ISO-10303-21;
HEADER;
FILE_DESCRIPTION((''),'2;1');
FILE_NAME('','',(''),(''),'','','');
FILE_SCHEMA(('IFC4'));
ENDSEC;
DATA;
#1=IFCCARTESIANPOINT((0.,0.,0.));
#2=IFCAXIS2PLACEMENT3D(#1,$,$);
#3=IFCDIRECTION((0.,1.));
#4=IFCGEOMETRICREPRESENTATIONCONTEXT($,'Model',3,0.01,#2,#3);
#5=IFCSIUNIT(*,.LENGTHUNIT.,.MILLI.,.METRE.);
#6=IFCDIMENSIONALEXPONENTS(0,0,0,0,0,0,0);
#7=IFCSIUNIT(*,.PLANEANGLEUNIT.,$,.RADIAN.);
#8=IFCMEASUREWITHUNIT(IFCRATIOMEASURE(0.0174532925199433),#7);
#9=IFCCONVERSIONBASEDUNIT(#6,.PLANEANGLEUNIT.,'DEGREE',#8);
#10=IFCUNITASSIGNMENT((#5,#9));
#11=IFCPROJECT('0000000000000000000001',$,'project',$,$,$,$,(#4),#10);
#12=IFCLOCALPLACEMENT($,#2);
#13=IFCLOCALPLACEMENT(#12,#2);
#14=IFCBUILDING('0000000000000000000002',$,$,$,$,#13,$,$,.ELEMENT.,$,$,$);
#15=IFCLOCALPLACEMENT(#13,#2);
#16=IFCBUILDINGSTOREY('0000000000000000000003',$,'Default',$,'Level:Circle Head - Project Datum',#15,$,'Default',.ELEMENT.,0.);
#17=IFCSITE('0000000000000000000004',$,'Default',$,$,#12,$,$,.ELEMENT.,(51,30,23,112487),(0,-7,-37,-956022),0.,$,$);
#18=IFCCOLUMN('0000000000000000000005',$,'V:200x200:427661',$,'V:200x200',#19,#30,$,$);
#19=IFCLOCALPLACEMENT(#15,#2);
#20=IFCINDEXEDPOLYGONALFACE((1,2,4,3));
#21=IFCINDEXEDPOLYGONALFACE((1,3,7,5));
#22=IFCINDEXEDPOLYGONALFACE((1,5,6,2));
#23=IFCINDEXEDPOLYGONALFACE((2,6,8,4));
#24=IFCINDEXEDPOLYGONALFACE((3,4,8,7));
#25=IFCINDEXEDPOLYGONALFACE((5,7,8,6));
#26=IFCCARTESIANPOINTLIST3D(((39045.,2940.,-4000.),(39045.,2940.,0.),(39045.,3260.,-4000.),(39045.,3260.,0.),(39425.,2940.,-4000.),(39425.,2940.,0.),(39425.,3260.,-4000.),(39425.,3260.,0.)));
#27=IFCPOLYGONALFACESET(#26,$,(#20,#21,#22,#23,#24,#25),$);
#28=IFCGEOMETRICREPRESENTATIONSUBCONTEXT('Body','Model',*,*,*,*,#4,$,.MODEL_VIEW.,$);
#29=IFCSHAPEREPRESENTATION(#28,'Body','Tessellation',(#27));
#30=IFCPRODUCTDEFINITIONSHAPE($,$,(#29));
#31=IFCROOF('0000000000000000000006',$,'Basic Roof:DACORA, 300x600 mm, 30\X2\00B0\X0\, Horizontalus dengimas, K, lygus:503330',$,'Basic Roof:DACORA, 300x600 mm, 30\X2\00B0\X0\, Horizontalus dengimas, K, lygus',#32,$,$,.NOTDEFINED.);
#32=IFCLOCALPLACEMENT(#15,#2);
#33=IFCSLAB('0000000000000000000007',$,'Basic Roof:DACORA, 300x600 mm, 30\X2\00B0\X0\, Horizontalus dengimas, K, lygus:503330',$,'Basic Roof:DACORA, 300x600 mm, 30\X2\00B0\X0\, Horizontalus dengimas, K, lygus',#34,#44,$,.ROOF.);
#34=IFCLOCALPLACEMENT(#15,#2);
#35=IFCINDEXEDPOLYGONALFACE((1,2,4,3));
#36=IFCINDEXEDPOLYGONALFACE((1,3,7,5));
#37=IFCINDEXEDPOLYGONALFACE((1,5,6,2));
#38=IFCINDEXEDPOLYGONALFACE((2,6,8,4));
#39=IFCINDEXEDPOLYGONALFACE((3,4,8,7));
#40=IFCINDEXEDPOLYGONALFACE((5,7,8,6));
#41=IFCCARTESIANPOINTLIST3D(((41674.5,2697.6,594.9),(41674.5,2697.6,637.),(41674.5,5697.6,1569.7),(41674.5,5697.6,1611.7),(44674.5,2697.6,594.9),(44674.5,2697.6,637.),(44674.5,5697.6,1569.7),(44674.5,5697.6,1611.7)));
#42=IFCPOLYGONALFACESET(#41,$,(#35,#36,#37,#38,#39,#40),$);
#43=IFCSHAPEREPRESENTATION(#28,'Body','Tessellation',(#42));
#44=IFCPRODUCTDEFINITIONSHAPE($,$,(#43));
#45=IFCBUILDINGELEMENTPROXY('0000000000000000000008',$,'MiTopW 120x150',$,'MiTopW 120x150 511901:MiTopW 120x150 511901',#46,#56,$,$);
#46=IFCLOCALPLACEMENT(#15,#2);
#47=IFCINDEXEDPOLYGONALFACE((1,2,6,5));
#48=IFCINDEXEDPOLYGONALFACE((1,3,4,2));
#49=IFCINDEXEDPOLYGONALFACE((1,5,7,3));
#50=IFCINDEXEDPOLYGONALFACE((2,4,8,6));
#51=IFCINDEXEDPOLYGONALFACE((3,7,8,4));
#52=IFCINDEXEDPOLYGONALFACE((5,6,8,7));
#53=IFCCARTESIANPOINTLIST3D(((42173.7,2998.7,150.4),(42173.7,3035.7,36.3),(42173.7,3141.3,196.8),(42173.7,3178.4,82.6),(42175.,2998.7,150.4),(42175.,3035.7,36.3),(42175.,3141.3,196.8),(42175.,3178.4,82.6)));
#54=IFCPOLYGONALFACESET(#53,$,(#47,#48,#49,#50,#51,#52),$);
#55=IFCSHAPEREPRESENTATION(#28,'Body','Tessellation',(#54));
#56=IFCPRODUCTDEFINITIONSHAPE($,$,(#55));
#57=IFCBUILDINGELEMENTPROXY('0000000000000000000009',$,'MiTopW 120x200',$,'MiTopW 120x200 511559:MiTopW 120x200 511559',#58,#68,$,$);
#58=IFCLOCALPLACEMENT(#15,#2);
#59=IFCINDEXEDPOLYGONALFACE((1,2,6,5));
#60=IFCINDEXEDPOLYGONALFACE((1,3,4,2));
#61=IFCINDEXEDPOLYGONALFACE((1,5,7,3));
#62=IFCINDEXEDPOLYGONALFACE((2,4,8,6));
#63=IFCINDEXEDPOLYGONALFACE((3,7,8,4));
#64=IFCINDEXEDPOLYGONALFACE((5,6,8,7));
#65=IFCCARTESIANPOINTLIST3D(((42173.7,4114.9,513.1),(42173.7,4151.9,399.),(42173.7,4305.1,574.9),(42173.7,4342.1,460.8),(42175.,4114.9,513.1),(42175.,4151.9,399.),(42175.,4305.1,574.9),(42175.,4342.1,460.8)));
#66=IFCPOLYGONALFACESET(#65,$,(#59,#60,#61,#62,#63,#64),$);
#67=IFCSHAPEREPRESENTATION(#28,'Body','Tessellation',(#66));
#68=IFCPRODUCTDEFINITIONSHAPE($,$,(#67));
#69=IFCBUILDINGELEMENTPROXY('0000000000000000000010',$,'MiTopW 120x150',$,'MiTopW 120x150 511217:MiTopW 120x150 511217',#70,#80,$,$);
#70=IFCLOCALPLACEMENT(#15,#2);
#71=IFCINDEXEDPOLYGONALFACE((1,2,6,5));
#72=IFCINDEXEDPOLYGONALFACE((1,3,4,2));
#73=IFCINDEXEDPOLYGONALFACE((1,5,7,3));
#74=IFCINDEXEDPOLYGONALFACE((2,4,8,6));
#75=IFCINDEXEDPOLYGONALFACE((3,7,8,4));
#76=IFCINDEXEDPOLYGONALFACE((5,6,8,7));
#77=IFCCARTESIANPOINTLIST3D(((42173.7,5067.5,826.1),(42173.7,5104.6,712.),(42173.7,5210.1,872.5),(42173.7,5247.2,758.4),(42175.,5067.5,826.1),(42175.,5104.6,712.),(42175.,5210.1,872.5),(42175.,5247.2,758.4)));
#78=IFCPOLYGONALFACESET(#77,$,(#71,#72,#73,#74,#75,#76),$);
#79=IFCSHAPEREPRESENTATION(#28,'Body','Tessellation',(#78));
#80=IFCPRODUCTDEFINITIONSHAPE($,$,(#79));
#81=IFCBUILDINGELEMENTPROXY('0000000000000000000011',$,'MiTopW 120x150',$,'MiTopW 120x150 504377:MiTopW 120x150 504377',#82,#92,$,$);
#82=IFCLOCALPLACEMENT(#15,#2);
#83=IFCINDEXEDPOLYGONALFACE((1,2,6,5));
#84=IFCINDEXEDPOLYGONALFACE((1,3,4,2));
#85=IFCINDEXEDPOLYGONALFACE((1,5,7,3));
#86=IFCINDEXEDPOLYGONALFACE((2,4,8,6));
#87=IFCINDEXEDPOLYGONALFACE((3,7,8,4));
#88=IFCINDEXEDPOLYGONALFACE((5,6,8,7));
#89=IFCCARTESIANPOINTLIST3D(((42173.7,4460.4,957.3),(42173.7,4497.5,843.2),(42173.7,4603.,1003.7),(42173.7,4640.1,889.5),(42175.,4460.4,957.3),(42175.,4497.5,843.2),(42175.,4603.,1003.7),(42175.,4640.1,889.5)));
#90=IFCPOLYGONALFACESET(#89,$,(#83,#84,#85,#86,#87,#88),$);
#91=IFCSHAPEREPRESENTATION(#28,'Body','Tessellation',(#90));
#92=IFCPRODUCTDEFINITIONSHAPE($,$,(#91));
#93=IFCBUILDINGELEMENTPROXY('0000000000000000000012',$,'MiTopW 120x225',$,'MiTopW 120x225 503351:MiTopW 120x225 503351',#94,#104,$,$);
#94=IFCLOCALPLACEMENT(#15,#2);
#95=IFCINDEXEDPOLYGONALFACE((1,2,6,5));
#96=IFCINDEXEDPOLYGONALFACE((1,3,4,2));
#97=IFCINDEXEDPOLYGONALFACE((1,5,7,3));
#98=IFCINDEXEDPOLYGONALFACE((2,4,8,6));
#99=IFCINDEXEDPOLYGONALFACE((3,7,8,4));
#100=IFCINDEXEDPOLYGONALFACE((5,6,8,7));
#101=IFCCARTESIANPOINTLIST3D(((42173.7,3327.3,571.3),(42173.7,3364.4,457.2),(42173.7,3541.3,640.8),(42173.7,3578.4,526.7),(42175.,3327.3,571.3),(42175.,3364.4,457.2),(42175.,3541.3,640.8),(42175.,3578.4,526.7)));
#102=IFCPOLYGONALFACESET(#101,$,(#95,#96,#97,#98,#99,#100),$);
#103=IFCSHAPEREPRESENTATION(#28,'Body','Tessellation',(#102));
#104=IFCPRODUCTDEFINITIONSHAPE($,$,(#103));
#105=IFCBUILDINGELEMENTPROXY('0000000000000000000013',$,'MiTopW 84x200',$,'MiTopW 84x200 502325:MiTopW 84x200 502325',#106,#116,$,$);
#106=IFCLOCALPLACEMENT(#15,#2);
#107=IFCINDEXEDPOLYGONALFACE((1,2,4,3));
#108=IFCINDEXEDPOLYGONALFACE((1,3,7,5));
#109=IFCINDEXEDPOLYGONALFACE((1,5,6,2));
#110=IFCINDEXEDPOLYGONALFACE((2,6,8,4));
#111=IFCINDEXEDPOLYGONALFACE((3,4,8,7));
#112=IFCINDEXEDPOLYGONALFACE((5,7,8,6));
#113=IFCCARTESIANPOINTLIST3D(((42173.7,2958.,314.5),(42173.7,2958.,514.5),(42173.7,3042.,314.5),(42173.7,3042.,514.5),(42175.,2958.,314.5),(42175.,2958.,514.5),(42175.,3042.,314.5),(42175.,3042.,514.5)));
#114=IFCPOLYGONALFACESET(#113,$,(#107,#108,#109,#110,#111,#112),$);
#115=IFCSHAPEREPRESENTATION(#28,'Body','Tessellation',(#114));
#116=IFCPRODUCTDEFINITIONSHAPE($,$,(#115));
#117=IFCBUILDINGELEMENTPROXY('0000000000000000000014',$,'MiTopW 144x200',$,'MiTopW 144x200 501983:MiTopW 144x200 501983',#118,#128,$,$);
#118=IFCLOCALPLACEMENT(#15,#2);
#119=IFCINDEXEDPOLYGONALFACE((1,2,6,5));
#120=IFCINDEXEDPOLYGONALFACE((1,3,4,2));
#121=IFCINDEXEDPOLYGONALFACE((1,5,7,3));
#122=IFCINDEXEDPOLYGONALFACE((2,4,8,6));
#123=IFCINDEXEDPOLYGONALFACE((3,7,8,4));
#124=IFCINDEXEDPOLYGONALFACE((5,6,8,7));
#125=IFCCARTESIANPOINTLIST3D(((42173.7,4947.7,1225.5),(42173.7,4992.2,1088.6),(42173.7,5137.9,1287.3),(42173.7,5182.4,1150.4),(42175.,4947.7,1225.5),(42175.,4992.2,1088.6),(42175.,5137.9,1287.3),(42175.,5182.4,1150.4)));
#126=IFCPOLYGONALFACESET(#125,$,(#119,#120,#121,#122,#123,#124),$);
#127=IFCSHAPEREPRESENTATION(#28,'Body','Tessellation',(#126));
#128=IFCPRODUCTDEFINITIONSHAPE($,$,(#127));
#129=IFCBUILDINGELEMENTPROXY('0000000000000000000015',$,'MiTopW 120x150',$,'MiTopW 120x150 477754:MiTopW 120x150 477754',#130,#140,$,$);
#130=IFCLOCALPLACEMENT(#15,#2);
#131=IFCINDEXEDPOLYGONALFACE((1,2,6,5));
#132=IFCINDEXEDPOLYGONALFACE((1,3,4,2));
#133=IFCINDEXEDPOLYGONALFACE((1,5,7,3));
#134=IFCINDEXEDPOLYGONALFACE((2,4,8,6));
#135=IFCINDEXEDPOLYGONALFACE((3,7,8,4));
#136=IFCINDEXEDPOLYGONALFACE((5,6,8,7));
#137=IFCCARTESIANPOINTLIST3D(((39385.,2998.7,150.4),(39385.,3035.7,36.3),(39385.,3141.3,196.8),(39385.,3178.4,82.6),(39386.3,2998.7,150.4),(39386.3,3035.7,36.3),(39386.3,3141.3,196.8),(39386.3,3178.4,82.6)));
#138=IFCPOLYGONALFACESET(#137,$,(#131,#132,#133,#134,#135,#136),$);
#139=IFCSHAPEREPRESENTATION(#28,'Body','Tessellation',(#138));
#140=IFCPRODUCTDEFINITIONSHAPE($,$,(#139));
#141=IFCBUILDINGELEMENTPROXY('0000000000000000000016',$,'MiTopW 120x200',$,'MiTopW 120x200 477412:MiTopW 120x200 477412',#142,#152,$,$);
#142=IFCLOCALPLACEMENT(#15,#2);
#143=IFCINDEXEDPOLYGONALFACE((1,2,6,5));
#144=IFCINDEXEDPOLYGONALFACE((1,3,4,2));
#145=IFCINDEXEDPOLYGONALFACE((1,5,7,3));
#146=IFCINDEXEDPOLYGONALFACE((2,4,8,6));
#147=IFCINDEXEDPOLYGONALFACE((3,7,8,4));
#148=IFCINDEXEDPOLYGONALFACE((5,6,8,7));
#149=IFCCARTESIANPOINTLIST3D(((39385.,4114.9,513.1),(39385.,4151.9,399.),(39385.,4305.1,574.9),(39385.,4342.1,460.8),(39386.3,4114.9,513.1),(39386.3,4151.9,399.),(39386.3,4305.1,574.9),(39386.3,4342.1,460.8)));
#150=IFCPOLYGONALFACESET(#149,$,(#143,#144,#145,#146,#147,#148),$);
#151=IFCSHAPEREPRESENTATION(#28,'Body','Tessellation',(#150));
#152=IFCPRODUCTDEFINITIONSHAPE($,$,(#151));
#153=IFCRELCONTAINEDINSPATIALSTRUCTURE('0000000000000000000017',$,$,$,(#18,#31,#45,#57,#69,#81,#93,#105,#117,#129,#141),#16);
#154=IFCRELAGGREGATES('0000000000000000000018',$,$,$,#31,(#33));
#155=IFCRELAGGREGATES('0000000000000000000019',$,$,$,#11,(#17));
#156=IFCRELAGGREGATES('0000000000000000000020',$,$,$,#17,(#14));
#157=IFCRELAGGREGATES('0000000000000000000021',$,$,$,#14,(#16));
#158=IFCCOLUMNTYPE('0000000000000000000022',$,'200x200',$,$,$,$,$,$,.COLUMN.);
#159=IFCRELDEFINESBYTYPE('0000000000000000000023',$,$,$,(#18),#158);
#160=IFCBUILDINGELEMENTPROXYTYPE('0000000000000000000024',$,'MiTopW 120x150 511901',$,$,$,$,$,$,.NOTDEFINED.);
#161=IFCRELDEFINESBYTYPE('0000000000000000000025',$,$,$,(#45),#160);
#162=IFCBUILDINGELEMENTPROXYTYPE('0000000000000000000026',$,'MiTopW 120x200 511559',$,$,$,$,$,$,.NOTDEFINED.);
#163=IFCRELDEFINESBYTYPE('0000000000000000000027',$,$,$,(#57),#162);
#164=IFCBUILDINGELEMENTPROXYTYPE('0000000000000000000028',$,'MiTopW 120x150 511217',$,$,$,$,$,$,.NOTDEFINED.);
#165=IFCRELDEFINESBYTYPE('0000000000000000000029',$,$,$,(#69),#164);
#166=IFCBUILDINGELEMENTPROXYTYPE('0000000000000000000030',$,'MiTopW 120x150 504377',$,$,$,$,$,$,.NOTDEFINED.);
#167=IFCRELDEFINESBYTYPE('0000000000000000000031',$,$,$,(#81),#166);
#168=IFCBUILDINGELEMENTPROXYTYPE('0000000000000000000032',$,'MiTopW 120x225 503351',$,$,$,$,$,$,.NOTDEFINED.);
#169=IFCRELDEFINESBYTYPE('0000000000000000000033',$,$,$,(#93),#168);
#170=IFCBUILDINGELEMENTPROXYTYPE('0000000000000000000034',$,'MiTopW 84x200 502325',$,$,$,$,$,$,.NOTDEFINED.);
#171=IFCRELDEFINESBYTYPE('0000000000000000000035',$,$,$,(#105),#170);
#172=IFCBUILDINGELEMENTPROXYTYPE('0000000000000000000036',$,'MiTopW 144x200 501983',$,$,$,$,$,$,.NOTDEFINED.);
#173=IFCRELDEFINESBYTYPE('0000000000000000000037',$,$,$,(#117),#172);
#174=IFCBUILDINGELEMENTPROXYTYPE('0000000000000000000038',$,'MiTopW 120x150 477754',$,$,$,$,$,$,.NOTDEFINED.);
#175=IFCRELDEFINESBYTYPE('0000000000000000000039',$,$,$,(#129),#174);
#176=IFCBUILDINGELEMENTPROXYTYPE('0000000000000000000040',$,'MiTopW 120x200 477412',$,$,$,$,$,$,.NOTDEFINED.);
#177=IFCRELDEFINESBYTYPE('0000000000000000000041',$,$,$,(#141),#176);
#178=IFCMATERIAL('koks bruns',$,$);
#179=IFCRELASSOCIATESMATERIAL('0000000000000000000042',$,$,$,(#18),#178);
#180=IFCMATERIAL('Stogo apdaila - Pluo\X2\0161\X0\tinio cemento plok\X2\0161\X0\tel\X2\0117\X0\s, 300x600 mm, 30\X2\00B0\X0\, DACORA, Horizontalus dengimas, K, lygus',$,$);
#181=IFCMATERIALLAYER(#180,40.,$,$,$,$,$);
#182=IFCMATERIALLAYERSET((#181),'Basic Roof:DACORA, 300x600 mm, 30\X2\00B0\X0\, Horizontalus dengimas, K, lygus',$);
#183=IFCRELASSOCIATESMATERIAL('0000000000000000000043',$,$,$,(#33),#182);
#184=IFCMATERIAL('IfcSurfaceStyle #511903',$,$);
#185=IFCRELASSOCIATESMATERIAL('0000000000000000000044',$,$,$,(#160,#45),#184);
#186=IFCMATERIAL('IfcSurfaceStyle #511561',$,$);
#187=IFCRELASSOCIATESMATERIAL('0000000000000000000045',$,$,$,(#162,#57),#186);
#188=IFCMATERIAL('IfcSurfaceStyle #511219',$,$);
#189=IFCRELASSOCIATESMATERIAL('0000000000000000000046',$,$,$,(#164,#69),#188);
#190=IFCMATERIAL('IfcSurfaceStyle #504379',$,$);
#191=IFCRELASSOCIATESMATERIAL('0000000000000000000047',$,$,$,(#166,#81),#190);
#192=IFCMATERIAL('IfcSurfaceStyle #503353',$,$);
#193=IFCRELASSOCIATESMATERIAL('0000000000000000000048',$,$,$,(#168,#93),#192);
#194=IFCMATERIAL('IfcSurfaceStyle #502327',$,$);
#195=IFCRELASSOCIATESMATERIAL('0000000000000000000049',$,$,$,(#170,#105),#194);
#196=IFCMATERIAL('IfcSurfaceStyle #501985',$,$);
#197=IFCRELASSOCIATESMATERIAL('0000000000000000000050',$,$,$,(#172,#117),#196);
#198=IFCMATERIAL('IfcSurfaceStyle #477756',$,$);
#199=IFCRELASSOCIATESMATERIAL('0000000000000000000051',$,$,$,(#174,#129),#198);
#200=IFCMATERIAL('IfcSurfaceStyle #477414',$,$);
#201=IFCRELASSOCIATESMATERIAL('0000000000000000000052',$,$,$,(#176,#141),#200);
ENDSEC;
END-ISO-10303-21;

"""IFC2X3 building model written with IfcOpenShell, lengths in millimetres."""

from ifc_helpers import new_model, entity, si_unit, converted_unit, direction, frame, frame_2d, origin, origin_2d_with_axis, place, context, subcontext, project, spatial, polyline, rectangle, outline, extrude, source, transform, mapped, material, layer, layer_set, type_object, type_shapes, element, aggregate, save


model = new_model("IFC2X3")

# Units and contexts
model_context = context("Model", 3, precision=0.01, world=origin(), true_north=direction((0.0, 1.0)))
body_context = subcontext(model_context, "Body", "Model", "MODEL_VIEW")
ifc_project = project(units=[si_unit("LENGTHUNIT", "METRE", prefix="MILLI"), converted_unit("PLANEANGLEUNIT", "DEGREE", entity("IfcRatioMeasure", 0.0174532925199433), si_unit("PLANEANGLEUNIT", "RADIAN"), dimensions=[0, 0, 0, 0, 0, 0, 0])], contexts=[model_context])

# Site, building, storey
site_placement = place(None, origin())
site = spatial("IfcSite", under=ifc_project, at=site_placement, Name="Default", CompositionType="ELEMENT", RefLatitude=(51, 30, 23, 112487), RefLongitude=(0, -7, -37, -956022), RefElevation=0.0)
building_placement = place(site_placement, origin())
building = spatial("IfcBuilding", under=site, at=building_placement, CompositionType="ELEMENT")
storey_placement = place(building_placement, origin())
storey = spatial("IfcBuildingStorey", under=building, at=storey_placement, Name="Default", ObjectType="Level:Circle Head - Project Datum", LongName="Default", CompositionType="ELEMENT", Elevation=0.0)

# Column
ifc_material_1 = material(Name="koks bruns")
column_type_1 = type_object("IfcColumnType", Name="200x200", PredefinedType="COLUMN")
shared_shape_1 = source(origin(), body_context, "Body", "SweptSolid", [
    extrude(rectangle(XDim=380.0, YDim=320.0, at=origin_2d_with_axis()), frame((160.0, 300.0, -4000.0), z_axis=(0.0, 0.0, 1.0), x_axis=(0.0, -1.0, 0.0)), (0.0, 0.0, 1.0), 4000.0),
])
type_shapes(column_type_1, [shared_shape_1])
column_placement = place(storey_placement, frame((39535.0, 2940.0, 0.0), z_axis=(0.0, 0.0, 1.0), x_axis=(0.0, 1.0, 0.0)))
element("IfcColumn", 1, at=column_placement, inside=storey, type_object=column_type_1, material=ifc_material_1, Name="V:200x200:427661", ObjectType="V:200x200", context=body_context, shape_type="MappedRepresentation", body=[
    mapped(shared_shape_1, transform((0.0, 0.0, 0.0), scale=1.0)),
])

# Roof, slab
roof_placement = place(storey_placement, frame((41674.5, 2697.6, 594.9)))
roof = element("IfcRoof", 2, at=roof_placement, inside=storey, Name="Basic Roof:DACORA, 300x600 mm, 30°, Horizontalus dengimas, K, lygus:503330", ObjectType="Basic Roof:DACORA, 300x600 mm, 30°, Horizontalus dengimas, K, lygus", ShapeType="NOTDEFINED")
ifc_material_2 = material(Name="Stogo apdaila - Pluoštinio cemento plokštelės, 300x600 mm, 30°, DACORA, Horizontalus dengimas, K, lygus")
ifc_layer = layer(ifc_material_2, 40.0)
ifc_layer_set = layer_set([ifc_layer], Name="Basic Roof:DACORA, 300x600 mm, 30°, Horizontalus dengimas, K, lygus")
slab_placement = place(roof_placement, origin())
slab = element("IfcSlab", 3, at=slab_placement, material=ifc_layer_set, Name="Basic Roof:DACORA, 300x600 mm, 30°, Horizontalus dengimas, K, lygus:503330", ObjectType="Basic Roof:DACORA, 300x600 mm, 30°, Horizontalus dengimas, K, lygus", PredefinedType="ROOF", context=body_context, shape_type="SweptSolid", body=[
    extrude(rectangle(XDim=3154.4, YDim=3000.0, at=frame_2d((0.0, 0.0), x_axis=(0.0, -1.0))), frame((1500.0, 1500.0, 487.4), z_axis=(0.0, -0.309017, 0.951057), x_axis=(1.0, 0.0, 0.0)), (0.0, 0.309017, 0.951057), 42.1),
])
aggregate(roof, [slab])

# Building element proxies
ifc_material_3 = material(Name="IfcSurfaceStyle #511903")
building_element_proxy_type_1 = type_object("IfcBuildingElementProxyType", Name="MiTopW 120x150 511901", PredefinedType="NOTDEFINED", material=ifc_material_3)
shared_shape_2 = source(origin(), body_context, "Body", "SweptSolid", [
    extrude(outline(polyline([(-75.0, -60.0), (75.0, -60.0), (75.0, 60.0), (-75.0, 60.0), (-75.0, -60.0)])), frame((75.0, 60.0, 0.0), z_axis=(0.0, 0.0, 1.0), x_axis=(-1.0, 0.0, 0.0)), (0.0, 0.0, 1.0), 1.3),
])
type_shapes(building_element_proxy_type_1, [shared_shape_2])
proxy_1_placement = place(building_placement, frame((42175.0, 2998.7, 150.4), z_axis=(-1.0, 0.0, 0.0), x_axis=(0.0, 0.951057, 0.309017)))
element("IfcBuildingElementProxy", 4, at=proxy_1_placement, inside=storey, type_object=building_element_proxy_type_1, material=ifc_material_3, Name="MiTopW 120x150", ObjectType="MiTopW 120x150 511901:MiTopW 120x150 511901", context=body_context, shape_type="MappedRepresentation", body=[
    mapped(shared_shape_2, transform((0.0, 0.0, 0.0), scale=1.0)),
])
ifc_material_4 = material(Name="IfcSurfaceStyle #511561")
building_element_proxy_type_2 = type_object("IfcBuildingElementProxyType", Name="MiTopW 120x200 511559", PredefinedType="NOTDEFINED", material=ifc_material_4)
shared_shape_3 = source(origin(), body_context, "Body", "SweptSolid", [
    extrude(outline(polyline([(-100.0, -60.0), (100.0, -60.0), (100.0, 60.0), (-100.0, 60.0), (-100.0, -60.0)])), frame((100.0, 60.0, 0.0), z_axis=(0.0, 0.0, 1.0), x_axis=(-1.0, 0.0, 0.0)), (0.0, 0.0, 1.0), 1.3),
])
type_shapes(building_element_proxy_type_2, [shared_shape_3])
proxy_2_placement = place(building_placement, frame((42175.0, 4114.9, 513.1), z_axis=(-1.0, 0.0, 0.0), x_axis=(0.0, 0.951057, 0.309017)))
element("IfcBuildingElementProxy", 5, at=proxy_2_placement, inside=storey, type_object=building_element_proxy_type_2, material=ifc_material_4, Name="MiTopW 120x200", ObjectType="MiTopW 120x200 511559:MiTopW 120x200 511559", context=body_context, shape_type="MappedRepresentation", body=[
    mapped(shared_shape_3, transform((0.0, 0.0, 0.0), scale=1.0)),
])
ifc_material_5 = material(Name="IfcSurfaceStyle #511219")
building_element_proxy_type_3 = type_object("IfcBuildingElementProxyType", Name="MiTopW 120x150 511217", PredefinedType="NOTDEFINED", material=ifc_material_5)
shared_shape_4 = source(origin(), body_context, "Body", "SweptSolid", [
    extrude(outline(polyline([(-75.0, -60.0), (75.0, -60.0), (75.0, 60.0), (-75.0, 60.0), (-75.0, -60.0)])), frame((75.0, 60.0, 0.0), z_axis=(0.0, 0.0, 1.0), x_axis=(-1.0, 0.0, 0.0)), (0.0, 0.0, 1.0), 1.3),
])
type_shapes(building_element_proxy_type_3, [shared_shape_4])
proxy_3_placement = place(building_placement, frame((42175.0, 5067.5, 826.1), z_axis=(-1.0, 0.0, 0.0), x_axis=(0.0, 0.951057, 0.309017)))
element("IfcBuildingElementProxy", 6, at=proxy_3_placement, inside=storey, type_object=building_element_proxy_type_3, material=ifc_material_5, Name="MiTopW 120x150", ObjectType="MiTopW 120x150 511217:MiTopW 120x150 511217", context=body_context, shape_type="MappedRepresentation", body=[
    mapped(shared_shape_4, transform((0.0, 0.0, 0.0), scale=1.0)),
])
ifc_material_6 = material(Name="IfcSurfaceStyle #504379")
building_element_proxy_type_4 = type_object("IfcBuildingElementProxyType", Name="MiTopW 120x150 504377", PredefinedType="NOTDEFINED", material=ifc_material_6)
shared_shape_5 = source(origin(), body_context, "Body", "SweptSolid", [
    extrude(outline(polyline([(-75.0, -60.0), (75.0, -60.0), (75.0, 60.0), (-75.0, 60.0), (-75.0, -60.0)])), frame((75.0, 60.0, 0.0), z_axis=(0.0, 0.0, 1.0), x_axis=(-1.0, 0.0, 0.0)), (0.0, 0.0, 1.0), 1.3),
])
type_shapes(building_element_proxy_type_4, [shared_shape_5])
proxy_4_placement = place(building_placement, frame((42175.0, 4460.4, 957.3), z_axis=(-1.0, 0.0, 0.0), x_axis=(0.0, 0.951057, 0.309017)))
element("IfcBuildingElementProxy", 7, at=proxy_4_placement, inside=storey, type_object=building_element_proxy_type_4, material=ifc_material_6, Name="MiTopW 120x150", ObjectType="MiTopW 120x150 504377:MiTopW 120x150 504377", context=body_context, shape_type="MappedRepresentation", body=[
    mapped(shared_shape_5, transform((0.0, 0.0, 0.0), scale=1.0)),
])
ifc_material_7 = material(Name="IfcSurfaceStyle #503353")
building_element_proxy_type_5 = type_object("IfcBuildingElementProxyType", Name="MiTopW 120x225 503351", PredefinedType="NOTDEFINED", material=ifc_material_7)
shared_shape_6 = source(origin(), body_context, "Body", "SweptSolid", [
    extrude(outline(polyline([(-112.5, -60.0), (112.5, -60.0), (112.5, 60.0), (-112.5, 60.0), (-112.5, -60.0)])), frame((112.5, 60.0, 0.0), z_axis=(0.0, 0.0, 1.0), x_axis=(-1.0, 0.0, 0.0)), (0.0, 0.0, 1.0), 1.3),
])
type_shapes(building_element_proxy_type_5, [shared_shape_6])
proxy_5_placement = place(building_placement, frame((42175.0, 3327.3, 571.3), z_axis=(-1.0, 0.0, 0.0), x_axis=(0.0, 0.951057, 0.309017)))
element("IfcBuildingElementProxy", 8, at=proxy_5_placement, inside=storey, type_object=building_element_proxy_type_5, material=ifc_material_7, Name="MiTopW 120x225", ObjectType="MiTopW 120x225 503351:MiTopW 120x225 503351", context=body_context, shape_type="MappedRepresentation", body=[
    mapped(shared_shape_6, transform((0.0, 0.0, 0.0), scale=1.0)),
])
ifc_material_8 = material(Name="IfcSurfaceStyle #502327")
building_element_proxy_type_6 = type_object("IfcBuildingElementProxyType", Name="MiTopW 84x200 502325", PredefinedType="NOTDEFINED", material=ifc_material_8)
shared_shape_7 = source(origin(), body_context, "Body", "SweptSolid", [
    extrude(rectangle(XDim=200.0, YDim=84.0, at=frame_2d((0.0, 0.0), x_axis=(1.0, 0.0))), frame((100.0, 42.0, 0.0), z_axis=(0.0, 0.0, 1.0), x_axis=(-1.0, 0.0, 0.0)), (0.0, 0.0, 1.0), 1.3),
])
type_shapes(building_element_proxy_type_6, [shared_shape_7])
proxy_6_placement = place(building_placement, frame((42175.0, 3042.0, 514.5), z_axis=(-1.0, 0.0, 0.0), x_axis=(0.0, 0.0, -1.0)))
element("IfcBuildingElementProxy", 9, at=proxy_6_placement, inside=storey, type_object=building_element_proxy_type_6, material=ifc_material_8, Name="MiTopW 84x200", ObjectType="MiTopW 84x200 502325:MiTopW 84x200 502325", context=body_context, shape_type="MappedRepresentation", body=[
    mapped(shared_shape_7, transform((0.0, 0.0, 0.0), scale=1.0)),
])
ifc_material_9 = material(Name="IfcSurfaceStyle #501985")
building_element_proxy_type_7 = type_object("IfcBuildingElementProxyType", Name="MiTopW 144x200 501983", PredefinedType="NOTDEFINED", material=ifc_material_9)
shared_shape_8 = source(origin(), body_context, "Body", "SweptSolid", [
    extrude(outline(polyline([(-100.0, -72.0), (100.0, -72.0), (100.0, 72.0), (-100.0, 72.0), (-100.0, -72.0)])), frame((100.0, 72.0, 0.0), z_axis=(0.0, 0.0, 1.0), x_axis=(-1.0, 0.0, 0.0)), (0.0, 0.0, 1.0), 1.3),
])
type_shapes(building_element_proxy_type_7, [shared_shape_8])
proxy_7_placement = place(building_placement, frame((42175.0, 4947.7, 1225.5), z_axis=(-1.0, 0.0, 0.0), x_axis=(0.0, 0.951057, 0.309017)))
element("IfcBuildingElementProxy", 10, at=proxy_7_placement, inside=storey, type_object=building_element_proxy_type_7, material=ifc_material_9, Name="MiTopW 144x200", ObjectType="MiTopW 144x200 501983:MiTopW 144x200 501983", context=body_context, shape_type="MappedRepresentation", body=[
    mapped(shared_shape_8, transform((0.0, 0.0, 0.0), scale=1.0)),
])
ifc_material_10 = material(Name="IfcSurfaceStyle #477756")
building_element_proxy_type_8 = type_object("IfcBuildingElementProxyType", Name="MiTopW 120x150 477754", PredefinedType="NOTDEFINED", material=ifc_material_10)
shared_shape_9 = source(origin(), body_context, "Body", "SweptSolid", [
    extrude(outline(polyline([(-75.0, -60.0), (75.0, -60.0), (75.0, 60.0), (-75.0, 60.0), (-75.0, -60.0)])), frame((75.0, 60.0, 0.0), z_axis=(0.0, 0.0, 1.0), x_axis=(-1.0, 0.0, 0.0)), (0.0, 0.0, 1.0), 1.3),
])
type_shapes(building_element_proxy_type_8, [shared_shape_9])
proxy_8_placement = place(building_placement, frame((39386.3, 2998.7, 150.4), z_axis=(-1.0, 0.0, 0.0), x_axis=(0.0, 0.951057, 0.309017)))
element("IfcBuildingElementProxy", 11, at=proxy_8_placement, inside=storey, type_object=building_element_proxy_type_8, material=ifc_material_10, Name="MiTopW 120x150", ObjectType="MiTopW 120x150 477754:MiTopW 120x150 477754", context=body_context, shape_type="MappedRepresentation", body=[
    mapped(shared_shape_9, transform((0.0, 0.0, 0.0), scale=1.0)),
])
ifc_material_11 = material(Name="IfcSurfaceStyle #477414")
building_element_proxy_type_9 = type_object("IfcBuildingElementProxyType", Name="MiTopW 120x200 477412", PredefinedType="NOTDEFINED", material=ifc_material_11)
shared_shape_10 = source(origin(), body_context, "Body", "SweptSolid", [
    extrude(outline(polyline([(-100.0, -60.0), (100.0, -60.0), (100.0, 60.0), (-100.0, 60.0), (-100.0, -60.0)])), frame((100.0, 60.0, 0.0), z_axis=(0.0, 0.0, 1.0), x_axis=(-1.0, 0.0, 0.0)), (0.0, 0.0, 1.0), 1.3),
])
type_shapes(building_element_proxy_type_9, [shared_shape_10])
proxy_9_placement = place(building_placement, frame((39386.3, 4114.9, 513.1), z_axis=(-1.0, 0.0, 0.0), x_axis=(0.0, 0.951057, 0.309017)))
element("IfcBuildingElementProxy", 12, at=proxy_9_placement, inside=storey, type_object=building_element_proxy_type_9, material=ifc_material_11, Name="MiTopW 120x200", ObjectType="MiTopW 120x200 477412:MiTopW 120x200 477412", context=body_context, shape_type="MappedRepresentation", body=[
    mapped(shared_shape_10, transform((0.0, 0.0, 0.0), scale=1.0)),
])

save(model, "model.ifc")
